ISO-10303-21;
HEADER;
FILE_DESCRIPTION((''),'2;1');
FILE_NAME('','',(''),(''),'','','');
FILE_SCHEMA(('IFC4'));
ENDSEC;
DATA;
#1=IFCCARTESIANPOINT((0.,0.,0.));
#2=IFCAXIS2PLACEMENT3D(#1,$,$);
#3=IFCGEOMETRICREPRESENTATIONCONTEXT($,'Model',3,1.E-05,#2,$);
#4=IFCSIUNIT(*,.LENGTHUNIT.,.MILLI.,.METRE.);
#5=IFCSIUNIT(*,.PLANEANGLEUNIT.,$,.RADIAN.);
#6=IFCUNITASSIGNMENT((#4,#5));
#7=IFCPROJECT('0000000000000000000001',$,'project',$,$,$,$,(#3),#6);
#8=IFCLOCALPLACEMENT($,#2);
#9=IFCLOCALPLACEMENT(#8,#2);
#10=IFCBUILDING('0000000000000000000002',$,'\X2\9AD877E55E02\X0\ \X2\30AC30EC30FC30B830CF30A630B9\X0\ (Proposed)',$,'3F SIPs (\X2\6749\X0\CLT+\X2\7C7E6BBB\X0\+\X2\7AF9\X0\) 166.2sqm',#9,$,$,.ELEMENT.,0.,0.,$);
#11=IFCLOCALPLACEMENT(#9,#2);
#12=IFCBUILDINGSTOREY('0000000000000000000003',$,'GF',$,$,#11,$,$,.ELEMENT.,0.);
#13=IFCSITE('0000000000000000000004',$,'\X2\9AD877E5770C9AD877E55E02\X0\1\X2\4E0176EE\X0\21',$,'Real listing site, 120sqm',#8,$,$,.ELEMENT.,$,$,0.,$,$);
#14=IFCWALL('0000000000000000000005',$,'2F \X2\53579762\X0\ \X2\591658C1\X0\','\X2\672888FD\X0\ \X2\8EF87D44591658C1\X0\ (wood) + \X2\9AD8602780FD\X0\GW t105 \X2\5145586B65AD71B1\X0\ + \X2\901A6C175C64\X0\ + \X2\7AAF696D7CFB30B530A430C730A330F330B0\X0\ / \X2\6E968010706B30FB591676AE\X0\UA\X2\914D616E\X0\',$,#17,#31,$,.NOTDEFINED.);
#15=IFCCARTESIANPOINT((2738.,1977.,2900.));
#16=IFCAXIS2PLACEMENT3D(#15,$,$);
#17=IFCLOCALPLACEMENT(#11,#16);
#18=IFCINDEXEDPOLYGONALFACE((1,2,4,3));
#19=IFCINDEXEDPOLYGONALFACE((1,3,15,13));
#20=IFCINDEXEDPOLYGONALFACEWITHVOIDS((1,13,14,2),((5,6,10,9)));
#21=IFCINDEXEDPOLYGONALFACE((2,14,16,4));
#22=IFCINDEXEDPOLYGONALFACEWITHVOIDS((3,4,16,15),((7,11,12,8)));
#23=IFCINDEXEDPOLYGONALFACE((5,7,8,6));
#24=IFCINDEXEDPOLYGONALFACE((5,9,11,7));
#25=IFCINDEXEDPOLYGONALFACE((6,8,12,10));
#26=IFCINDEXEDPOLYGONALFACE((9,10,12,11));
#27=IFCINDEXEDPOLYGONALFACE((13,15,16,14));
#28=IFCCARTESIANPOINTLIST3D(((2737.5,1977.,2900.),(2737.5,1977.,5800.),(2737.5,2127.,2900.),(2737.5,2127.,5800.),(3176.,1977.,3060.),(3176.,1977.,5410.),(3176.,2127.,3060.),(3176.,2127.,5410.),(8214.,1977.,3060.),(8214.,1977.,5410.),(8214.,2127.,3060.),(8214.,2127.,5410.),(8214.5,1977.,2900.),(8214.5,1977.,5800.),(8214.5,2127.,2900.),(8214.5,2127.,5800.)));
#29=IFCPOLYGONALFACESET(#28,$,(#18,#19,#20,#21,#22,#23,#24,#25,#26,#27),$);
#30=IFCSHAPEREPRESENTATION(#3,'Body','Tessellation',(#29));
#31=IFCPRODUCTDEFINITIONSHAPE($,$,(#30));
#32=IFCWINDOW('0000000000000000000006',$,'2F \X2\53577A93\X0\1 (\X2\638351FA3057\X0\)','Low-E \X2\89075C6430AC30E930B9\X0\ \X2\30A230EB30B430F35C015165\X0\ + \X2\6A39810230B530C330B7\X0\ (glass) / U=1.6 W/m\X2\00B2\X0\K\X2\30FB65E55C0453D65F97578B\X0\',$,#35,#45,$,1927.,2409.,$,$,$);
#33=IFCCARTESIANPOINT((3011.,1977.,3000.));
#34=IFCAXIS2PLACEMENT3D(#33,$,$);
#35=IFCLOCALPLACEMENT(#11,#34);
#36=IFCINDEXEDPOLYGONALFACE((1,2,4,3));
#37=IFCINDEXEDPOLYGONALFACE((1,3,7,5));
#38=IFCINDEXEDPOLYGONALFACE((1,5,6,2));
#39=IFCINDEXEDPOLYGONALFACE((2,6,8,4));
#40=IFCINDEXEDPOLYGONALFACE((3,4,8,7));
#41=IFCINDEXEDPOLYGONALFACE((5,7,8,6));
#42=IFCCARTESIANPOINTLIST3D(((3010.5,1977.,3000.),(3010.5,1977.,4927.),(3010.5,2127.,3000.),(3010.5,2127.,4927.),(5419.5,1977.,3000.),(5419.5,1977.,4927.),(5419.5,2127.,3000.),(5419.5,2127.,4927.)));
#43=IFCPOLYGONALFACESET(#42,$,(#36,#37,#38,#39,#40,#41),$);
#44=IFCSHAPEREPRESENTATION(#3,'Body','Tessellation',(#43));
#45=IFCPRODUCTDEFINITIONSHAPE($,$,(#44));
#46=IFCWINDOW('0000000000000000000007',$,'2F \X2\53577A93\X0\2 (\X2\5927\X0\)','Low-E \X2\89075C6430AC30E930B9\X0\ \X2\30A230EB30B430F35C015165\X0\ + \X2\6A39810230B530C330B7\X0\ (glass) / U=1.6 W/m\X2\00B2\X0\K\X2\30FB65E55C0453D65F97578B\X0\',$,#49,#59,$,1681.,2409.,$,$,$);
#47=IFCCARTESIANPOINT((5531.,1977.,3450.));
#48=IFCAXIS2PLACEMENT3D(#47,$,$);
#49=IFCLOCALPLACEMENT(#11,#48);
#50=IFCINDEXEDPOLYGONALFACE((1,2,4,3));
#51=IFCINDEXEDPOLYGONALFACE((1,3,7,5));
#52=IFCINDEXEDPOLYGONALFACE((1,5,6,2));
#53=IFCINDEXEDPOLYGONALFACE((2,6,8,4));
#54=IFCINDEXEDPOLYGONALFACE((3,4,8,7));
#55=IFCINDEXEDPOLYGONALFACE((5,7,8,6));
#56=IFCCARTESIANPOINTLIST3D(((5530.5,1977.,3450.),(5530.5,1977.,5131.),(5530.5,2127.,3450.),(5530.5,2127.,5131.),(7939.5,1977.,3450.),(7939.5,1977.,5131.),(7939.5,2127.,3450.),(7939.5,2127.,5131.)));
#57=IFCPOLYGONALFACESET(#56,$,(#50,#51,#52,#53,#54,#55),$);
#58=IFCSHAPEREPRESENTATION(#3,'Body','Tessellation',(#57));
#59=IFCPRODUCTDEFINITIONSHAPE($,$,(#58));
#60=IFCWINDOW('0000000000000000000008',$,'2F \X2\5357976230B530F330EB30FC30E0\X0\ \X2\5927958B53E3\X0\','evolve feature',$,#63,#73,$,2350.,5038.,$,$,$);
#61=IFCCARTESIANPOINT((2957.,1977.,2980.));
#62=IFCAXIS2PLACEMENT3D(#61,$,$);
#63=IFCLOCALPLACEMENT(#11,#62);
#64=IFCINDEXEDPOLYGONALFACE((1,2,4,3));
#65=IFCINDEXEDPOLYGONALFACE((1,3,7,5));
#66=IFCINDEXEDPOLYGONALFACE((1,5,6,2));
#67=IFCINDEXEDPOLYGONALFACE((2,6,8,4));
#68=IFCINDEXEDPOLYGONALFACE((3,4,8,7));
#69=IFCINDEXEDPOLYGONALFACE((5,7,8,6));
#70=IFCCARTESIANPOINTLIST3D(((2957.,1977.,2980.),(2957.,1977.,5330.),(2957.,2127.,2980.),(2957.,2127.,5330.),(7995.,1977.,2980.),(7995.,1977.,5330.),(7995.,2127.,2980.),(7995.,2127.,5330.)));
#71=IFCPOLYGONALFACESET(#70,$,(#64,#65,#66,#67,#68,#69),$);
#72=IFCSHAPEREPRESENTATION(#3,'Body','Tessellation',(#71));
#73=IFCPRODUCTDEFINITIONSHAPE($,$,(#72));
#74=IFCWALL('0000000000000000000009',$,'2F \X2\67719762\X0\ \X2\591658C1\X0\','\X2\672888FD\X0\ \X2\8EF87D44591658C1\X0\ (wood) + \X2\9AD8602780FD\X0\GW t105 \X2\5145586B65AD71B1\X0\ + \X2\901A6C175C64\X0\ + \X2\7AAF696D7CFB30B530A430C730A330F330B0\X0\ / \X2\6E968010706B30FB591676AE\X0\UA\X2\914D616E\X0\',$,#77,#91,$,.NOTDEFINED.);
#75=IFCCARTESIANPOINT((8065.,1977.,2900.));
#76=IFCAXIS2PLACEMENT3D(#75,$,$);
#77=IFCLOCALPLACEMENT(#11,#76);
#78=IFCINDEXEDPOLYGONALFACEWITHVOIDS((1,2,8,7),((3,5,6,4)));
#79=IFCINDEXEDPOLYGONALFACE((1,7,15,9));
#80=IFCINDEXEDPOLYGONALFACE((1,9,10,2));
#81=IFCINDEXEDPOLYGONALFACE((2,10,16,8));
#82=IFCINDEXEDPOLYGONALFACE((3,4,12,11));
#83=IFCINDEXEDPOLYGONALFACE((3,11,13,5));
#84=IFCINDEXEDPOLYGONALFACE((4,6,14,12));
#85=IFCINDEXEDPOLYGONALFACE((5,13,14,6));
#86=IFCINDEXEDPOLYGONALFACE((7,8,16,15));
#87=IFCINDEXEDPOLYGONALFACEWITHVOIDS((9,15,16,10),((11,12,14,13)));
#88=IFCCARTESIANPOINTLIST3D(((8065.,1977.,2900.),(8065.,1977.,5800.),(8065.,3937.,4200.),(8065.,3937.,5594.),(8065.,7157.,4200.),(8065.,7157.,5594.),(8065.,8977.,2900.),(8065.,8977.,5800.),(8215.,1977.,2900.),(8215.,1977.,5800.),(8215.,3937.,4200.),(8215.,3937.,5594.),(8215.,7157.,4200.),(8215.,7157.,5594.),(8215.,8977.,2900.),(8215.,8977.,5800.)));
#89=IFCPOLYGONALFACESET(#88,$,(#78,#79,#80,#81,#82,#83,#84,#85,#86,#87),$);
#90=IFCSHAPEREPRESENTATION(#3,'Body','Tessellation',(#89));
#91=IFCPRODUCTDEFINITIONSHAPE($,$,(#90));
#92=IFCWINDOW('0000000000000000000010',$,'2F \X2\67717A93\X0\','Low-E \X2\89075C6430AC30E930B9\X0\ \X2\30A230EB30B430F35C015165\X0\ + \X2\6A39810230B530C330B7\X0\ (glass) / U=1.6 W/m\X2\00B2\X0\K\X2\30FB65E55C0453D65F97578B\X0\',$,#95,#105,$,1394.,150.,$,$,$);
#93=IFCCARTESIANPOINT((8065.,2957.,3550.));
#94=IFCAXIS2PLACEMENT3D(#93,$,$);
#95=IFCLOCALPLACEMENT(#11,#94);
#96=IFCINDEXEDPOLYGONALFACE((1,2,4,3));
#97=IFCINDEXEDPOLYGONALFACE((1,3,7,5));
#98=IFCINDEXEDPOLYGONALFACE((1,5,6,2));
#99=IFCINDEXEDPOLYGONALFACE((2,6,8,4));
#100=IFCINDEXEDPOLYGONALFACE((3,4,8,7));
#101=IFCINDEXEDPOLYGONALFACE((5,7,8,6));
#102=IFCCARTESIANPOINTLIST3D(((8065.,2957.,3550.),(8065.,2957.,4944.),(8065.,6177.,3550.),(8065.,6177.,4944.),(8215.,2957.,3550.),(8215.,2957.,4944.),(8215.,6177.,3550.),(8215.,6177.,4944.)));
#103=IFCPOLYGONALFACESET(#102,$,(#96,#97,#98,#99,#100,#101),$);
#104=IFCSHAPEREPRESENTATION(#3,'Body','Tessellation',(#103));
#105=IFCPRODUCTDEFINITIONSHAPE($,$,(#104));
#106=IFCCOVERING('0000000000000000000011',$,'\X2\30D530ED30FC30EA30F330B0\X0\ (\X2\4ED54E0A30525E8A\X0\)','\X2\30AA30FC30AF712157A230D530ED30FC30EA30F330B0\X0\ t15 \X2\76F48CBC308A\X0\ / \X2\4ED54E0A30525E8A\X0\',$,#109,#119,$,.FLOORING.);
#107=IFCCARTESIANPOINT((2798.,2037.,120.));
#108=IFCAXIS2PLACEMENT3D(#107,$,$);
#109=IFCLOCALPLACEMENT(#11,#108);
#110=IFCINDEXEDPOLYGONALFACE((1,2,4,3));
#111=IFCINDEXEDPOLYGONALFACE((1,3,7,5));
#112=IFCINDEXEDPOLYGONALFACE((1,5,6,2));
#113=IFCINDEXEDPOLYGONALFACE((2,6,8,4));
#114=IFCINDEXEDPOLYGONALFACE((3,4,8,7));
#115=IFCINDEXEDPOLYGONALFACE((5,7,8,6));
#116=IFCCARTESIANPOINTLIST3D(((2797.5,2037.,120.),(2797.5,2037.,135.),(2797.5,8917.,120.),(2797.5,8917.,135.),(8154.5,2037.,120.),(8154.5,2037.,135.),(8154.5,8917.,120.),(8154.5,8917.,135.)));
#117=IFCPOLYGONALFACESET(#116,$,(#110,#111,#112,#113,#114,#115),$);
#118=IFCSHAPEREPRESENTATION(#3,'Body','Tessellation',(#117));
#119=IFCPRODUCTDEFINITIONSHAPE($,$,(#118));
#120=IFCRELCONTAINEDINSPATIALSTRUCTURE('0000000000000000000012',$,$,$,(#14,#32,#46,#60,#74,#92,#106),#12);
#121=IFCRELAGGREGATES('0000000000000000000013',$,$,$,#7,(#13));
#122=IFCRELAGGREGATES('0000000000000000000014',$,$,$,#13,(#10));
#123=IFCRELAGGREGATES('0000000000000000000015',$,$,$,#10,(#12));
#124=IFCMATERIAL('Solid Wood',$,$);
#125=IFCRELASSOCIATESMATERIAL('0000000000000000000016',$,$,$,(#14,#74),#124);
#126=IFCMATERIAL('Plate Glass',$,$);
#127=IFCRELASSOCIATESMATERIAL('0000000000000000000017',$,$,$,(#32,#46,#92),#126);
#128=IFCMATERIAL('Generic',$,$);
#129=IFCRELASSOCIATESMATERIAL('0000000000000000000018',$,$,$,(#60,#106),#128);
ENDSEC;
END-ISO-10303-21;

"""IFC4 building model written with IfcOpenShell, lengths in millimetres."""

from ifc_helpers import new_model, si_unit, frame, frame_2d, origin, place, context, project, spatial, rectangle, extrude, material, element, fill, save


model = new_model("IFC4")

# Units and contexts
model_context = context("Model", 3, precision=1e-05, world=origin())
ifc_project = project(units=[si_unit("LENGTHUNIT", "METRE", prefix="MILLI"), si_unit("PLANEANGLEUNIT", "RADIAN")], contexts=[model_context])

# Site, building, storey
site_placement = place(None, origin())
site = spatial("IfcSite", under=ifc_project, at=site_placement, Name="高知県高知市1丁目21", ObjectType="Real listing site, 120sqm", CompositionType="ELEMENT", RefElevation=0.0)
building_placement = place(site_placement, origin())
building = spatial("IfcBuilding", under=site, at=building_placement, Name="高知市 ガレージハウス (Proposed)", ObjectType="3F SIPs (杉CLT+籾殻+竹) 166.2sqm", CompositionType="ELEMENT", ElevationOfRefHeight=0.0, ElevationOfTerrain=0.0)
storey_placement = place(building_placement, origin())
storey = spatial("IfcBuildingStorey", under=building, at=storey_placement, Name="GF", CompositionType="ELEMENT", Elevation=0.0)

# Shared definitions
ifc_material_1 = material(Name="Solid Wood")
ifc_material_2 = material(Name="Generic")

# Shared definitions
ifc_material_3 = material(Name="Plate Glass")

# Wall, openings, windows
wall_1_placement = place(storey_placement, frame((2738.0, 1977.0, 2900.0)))
wall_1 = element("IfcWall", 1, at=wall_1_placement, inside=storey, material=ifc_material_1, Name="2F 南面 外壁", Description="木製 軸組外壁 (wood) + 高性能GW t105 充填断熱 + 通気層 + 窯業系サイディング / 準耐火・外皮UA配慮", PredefinedType="NOTDEFINED", context=model_context, shape_type="SweptSolid", body=[
    extrude(rectangle(XDim=5477.0, YDim=150.0, at=frame_2d((2738.0, 75.0))), frame((2738.0, 1977.0, 2900.0)), (0.0, 0.0, 1.0), 2900.0),
])
opening_1_placement = place(storey_placement, frame((3011.0, 1977.0, 3000.0)))
opening_1 = element("IfcOpeningElement", 2, at=opening_1_placement, cuts=wall_1, PredefinedType="NOTDEFINED", context=model_context, shape_type="SweptSolid", body=[
    extrude(rectangle(XDim=2409.0, YDim=150.0, at=frame_2d((1204.0, 75.0))), frame((3011.0, 1977.0, 3000.0)), (0.0, 0.0, 1.0), 1927.0),
])
opening_2_placement = place(storey_placement, frame((5531.0, 1977.0, 3450.0)))
opening_2 = element("IfcOpeningElement", 3, at=opening_2_placement, cuts=wall_1, PredefinedType="NOTDEFINED", context=model_context, shape_type="SweptSolid", body=[
    extrude(rectangle(XDim=2409.0, YDim=150.0, at=frame_2d((1204.0, 75.0))), frame((5531.0, 1977.0, 3450.0)), (0.0, 0.0, 1.0), 1681.0),
])
opening_3_placement = place(storey_placement, frame((2957.0, 1977.0, 2980.0)))
opening_3 = element("IfcOpeningElement", 4, at=opening_3_placement, cuts=wall_1, PredefinedType="NOTDEFINED", context=model_context, shape_type="SweptSolid", body=[
    extrude(rectangle(XDim=5038.0, YDim=150.0, at=frame_2d((2519.0, 75.0))), frame((2957.0, 1977.0, 2980.0)), (0.0, 0.0, 1.0), 2350.0),
])
window_1_placement = place(storey_placement, frame((3011.0, 1977.0, 3000.0)))
window_1 = element("IfcWindow", 5, at=window_1_placement, inside=storey, material=ifc_material_3, Name="2F 南窓1 (掃出し)", Description="Low-E 複層ガラス アルゴン封入 + 樹脂サッシ (glass) / U=1.6 W/m²K・日射取得型", OverallHeight=1927.0, OverallWidth=2409.0, context=model_context, shape_type="SweptSolid", body=[
    extrude(rectangle(XDim=2409.0, YDim=150.0, at=frame_2d((1204.0, 75.0))), frame((3011.0, 1977.0, 3000.0)), (0.0, 0.0, 1.0), 1927.0),
])
fill(opening_1, window_1)
window_2_placement = place(storey_placement, frame((5531.0, 1977.0, 3450.0)))
window_2 = element("IfcWindow", 6, at=window_2_placement, inside=storey, material=ifc_material_3, Name="2F 南窓2 (大)", Description="Low-E 複層ガラス アルゴン封入 + 樹脂サッシ (glass) / U=1.6 W/m²K・日射取得型", OverallHeight=1681.0, OverallWidth=2409.0, context=model_context, shape_type="SweptSolid", body=[
    extrude(rectangle(XDim=2409.0, YDim=150.0, at=frame_2d((1204.0, 75.0))), frame((5531.0, 1977.0, 3450.0)), (0.0, 0.0, 1.0), 1681.0),
])
fill(opening_2, window_2)
window_3_placement = place(storey_placement, frame((2957.0, 1977.0, 2980.0)))
window_3 = element("IfcWindow", 7, at=window_3_placement, inside=storey, material=ifc_material_2, Name="2F 南面サンルーム 大開口", Description="evolve feature", OverallHeight=2350.0, OverallWidth=5038.0, context=model_context, shape_type="SweptSolid", body=[
    extrude(rectangle(XDim=5038.0, YDim=150.0, at=frame_2d((2519.0, 75.0))), frame((2957.0, 1977.0, 2980.0)), (0.0, 0.0, 1.0), 2350.0),
])
fill(opening_3, window_3)

# Wall, opening, window
wall_2_placement = place(storey_placement, frame((8065.0, 1977.0, 2900.0)))
wall_2 = element("IfcWall", 8, at=wall_2_placement, inside=storey, material=ifc_material_1, Name="2F 東面 外壁", Description="木製 軸組外壁 (wood) + 高性能GW t105 充填断熱 + 通気層 + 窯業系サイディング / 準耐火・外皮UA配慮", PredefinedType="NOTDEFINED", context=model_context, shape_type="SweptSolid", body=[
    extrude(rectangle(XDim=150.0, YDim=7000.0, at=frame_2d((75.0, 3500.0))), frame((8065.0, 1977.0, 2900.0)), (0.0, 0.0, 1.0), 2900.0),
])
opening_4_placement = place(storey_placement, frame((8065.0, 2957.0, 3550.0)))
opening_4 = element("IfcOpeningElement", 9, at=opening_4_placement, cuts=wall_2, PredefinedType="NOTDEFINED", context=model_context, shape_type="SweptSolid", body=[
    extrude(rectangle(XDim=150.0, YDim=3220.0, at=frame_2d((75.0, 1610.0))), frame((8065.0, 2957.0, 3550.0)), (0.0, 0.0, 1.0), 1394.0),
])
window_4_placement = place(storey_placement, frame((8065.0, 2957.0, 3550.0)))
window_4 = element("IfcWindow", 10, at=window_4_placement, inside=storey, material=ifc_material_3, Name="2F 東窓", Description="Low-E 複層ガラス アルゴン封入 + 樹脂サッシ (glass) / U=1.6 W/m²K・日射取得型", OverallHeight=1394.0, OverallWidth=150.0, context=model_context, shape_type="SweptSolid", body=[
    extrude(rectangle(XDim=150.0, YDim=3220.0, at=frame_2d((75.0, 1610.0))), frame((8065.0, 2957.0, 3550.0)), (0.0, 0.0, 1.0), 1394.0),
])
fill(opening_4, window_4)

# Covering
covering_placement = place(storey_placement, frame((2798.0, 2037.0, 120.0)))
element("IfcCovering", 11, at=covering_placement, inside=storey, material=ifc_material_2, Name="フローリング (仕上げ床)", Description="オーク無垢フローリング t15 直貼り / 仕上げ床", PredefinedType="FLOORING", context=model_context, shape_type="SweptSolid", body=[
    extrude(rectangle(XDim=5357.0, YDim=6880.0, at=frame_2d((2678.0, 3440.0))), frame((2798.0, 2037.0, 120.0)), (0.0, 0.0, 1.0), 15.0),
])

save(model, "model.ifc")
